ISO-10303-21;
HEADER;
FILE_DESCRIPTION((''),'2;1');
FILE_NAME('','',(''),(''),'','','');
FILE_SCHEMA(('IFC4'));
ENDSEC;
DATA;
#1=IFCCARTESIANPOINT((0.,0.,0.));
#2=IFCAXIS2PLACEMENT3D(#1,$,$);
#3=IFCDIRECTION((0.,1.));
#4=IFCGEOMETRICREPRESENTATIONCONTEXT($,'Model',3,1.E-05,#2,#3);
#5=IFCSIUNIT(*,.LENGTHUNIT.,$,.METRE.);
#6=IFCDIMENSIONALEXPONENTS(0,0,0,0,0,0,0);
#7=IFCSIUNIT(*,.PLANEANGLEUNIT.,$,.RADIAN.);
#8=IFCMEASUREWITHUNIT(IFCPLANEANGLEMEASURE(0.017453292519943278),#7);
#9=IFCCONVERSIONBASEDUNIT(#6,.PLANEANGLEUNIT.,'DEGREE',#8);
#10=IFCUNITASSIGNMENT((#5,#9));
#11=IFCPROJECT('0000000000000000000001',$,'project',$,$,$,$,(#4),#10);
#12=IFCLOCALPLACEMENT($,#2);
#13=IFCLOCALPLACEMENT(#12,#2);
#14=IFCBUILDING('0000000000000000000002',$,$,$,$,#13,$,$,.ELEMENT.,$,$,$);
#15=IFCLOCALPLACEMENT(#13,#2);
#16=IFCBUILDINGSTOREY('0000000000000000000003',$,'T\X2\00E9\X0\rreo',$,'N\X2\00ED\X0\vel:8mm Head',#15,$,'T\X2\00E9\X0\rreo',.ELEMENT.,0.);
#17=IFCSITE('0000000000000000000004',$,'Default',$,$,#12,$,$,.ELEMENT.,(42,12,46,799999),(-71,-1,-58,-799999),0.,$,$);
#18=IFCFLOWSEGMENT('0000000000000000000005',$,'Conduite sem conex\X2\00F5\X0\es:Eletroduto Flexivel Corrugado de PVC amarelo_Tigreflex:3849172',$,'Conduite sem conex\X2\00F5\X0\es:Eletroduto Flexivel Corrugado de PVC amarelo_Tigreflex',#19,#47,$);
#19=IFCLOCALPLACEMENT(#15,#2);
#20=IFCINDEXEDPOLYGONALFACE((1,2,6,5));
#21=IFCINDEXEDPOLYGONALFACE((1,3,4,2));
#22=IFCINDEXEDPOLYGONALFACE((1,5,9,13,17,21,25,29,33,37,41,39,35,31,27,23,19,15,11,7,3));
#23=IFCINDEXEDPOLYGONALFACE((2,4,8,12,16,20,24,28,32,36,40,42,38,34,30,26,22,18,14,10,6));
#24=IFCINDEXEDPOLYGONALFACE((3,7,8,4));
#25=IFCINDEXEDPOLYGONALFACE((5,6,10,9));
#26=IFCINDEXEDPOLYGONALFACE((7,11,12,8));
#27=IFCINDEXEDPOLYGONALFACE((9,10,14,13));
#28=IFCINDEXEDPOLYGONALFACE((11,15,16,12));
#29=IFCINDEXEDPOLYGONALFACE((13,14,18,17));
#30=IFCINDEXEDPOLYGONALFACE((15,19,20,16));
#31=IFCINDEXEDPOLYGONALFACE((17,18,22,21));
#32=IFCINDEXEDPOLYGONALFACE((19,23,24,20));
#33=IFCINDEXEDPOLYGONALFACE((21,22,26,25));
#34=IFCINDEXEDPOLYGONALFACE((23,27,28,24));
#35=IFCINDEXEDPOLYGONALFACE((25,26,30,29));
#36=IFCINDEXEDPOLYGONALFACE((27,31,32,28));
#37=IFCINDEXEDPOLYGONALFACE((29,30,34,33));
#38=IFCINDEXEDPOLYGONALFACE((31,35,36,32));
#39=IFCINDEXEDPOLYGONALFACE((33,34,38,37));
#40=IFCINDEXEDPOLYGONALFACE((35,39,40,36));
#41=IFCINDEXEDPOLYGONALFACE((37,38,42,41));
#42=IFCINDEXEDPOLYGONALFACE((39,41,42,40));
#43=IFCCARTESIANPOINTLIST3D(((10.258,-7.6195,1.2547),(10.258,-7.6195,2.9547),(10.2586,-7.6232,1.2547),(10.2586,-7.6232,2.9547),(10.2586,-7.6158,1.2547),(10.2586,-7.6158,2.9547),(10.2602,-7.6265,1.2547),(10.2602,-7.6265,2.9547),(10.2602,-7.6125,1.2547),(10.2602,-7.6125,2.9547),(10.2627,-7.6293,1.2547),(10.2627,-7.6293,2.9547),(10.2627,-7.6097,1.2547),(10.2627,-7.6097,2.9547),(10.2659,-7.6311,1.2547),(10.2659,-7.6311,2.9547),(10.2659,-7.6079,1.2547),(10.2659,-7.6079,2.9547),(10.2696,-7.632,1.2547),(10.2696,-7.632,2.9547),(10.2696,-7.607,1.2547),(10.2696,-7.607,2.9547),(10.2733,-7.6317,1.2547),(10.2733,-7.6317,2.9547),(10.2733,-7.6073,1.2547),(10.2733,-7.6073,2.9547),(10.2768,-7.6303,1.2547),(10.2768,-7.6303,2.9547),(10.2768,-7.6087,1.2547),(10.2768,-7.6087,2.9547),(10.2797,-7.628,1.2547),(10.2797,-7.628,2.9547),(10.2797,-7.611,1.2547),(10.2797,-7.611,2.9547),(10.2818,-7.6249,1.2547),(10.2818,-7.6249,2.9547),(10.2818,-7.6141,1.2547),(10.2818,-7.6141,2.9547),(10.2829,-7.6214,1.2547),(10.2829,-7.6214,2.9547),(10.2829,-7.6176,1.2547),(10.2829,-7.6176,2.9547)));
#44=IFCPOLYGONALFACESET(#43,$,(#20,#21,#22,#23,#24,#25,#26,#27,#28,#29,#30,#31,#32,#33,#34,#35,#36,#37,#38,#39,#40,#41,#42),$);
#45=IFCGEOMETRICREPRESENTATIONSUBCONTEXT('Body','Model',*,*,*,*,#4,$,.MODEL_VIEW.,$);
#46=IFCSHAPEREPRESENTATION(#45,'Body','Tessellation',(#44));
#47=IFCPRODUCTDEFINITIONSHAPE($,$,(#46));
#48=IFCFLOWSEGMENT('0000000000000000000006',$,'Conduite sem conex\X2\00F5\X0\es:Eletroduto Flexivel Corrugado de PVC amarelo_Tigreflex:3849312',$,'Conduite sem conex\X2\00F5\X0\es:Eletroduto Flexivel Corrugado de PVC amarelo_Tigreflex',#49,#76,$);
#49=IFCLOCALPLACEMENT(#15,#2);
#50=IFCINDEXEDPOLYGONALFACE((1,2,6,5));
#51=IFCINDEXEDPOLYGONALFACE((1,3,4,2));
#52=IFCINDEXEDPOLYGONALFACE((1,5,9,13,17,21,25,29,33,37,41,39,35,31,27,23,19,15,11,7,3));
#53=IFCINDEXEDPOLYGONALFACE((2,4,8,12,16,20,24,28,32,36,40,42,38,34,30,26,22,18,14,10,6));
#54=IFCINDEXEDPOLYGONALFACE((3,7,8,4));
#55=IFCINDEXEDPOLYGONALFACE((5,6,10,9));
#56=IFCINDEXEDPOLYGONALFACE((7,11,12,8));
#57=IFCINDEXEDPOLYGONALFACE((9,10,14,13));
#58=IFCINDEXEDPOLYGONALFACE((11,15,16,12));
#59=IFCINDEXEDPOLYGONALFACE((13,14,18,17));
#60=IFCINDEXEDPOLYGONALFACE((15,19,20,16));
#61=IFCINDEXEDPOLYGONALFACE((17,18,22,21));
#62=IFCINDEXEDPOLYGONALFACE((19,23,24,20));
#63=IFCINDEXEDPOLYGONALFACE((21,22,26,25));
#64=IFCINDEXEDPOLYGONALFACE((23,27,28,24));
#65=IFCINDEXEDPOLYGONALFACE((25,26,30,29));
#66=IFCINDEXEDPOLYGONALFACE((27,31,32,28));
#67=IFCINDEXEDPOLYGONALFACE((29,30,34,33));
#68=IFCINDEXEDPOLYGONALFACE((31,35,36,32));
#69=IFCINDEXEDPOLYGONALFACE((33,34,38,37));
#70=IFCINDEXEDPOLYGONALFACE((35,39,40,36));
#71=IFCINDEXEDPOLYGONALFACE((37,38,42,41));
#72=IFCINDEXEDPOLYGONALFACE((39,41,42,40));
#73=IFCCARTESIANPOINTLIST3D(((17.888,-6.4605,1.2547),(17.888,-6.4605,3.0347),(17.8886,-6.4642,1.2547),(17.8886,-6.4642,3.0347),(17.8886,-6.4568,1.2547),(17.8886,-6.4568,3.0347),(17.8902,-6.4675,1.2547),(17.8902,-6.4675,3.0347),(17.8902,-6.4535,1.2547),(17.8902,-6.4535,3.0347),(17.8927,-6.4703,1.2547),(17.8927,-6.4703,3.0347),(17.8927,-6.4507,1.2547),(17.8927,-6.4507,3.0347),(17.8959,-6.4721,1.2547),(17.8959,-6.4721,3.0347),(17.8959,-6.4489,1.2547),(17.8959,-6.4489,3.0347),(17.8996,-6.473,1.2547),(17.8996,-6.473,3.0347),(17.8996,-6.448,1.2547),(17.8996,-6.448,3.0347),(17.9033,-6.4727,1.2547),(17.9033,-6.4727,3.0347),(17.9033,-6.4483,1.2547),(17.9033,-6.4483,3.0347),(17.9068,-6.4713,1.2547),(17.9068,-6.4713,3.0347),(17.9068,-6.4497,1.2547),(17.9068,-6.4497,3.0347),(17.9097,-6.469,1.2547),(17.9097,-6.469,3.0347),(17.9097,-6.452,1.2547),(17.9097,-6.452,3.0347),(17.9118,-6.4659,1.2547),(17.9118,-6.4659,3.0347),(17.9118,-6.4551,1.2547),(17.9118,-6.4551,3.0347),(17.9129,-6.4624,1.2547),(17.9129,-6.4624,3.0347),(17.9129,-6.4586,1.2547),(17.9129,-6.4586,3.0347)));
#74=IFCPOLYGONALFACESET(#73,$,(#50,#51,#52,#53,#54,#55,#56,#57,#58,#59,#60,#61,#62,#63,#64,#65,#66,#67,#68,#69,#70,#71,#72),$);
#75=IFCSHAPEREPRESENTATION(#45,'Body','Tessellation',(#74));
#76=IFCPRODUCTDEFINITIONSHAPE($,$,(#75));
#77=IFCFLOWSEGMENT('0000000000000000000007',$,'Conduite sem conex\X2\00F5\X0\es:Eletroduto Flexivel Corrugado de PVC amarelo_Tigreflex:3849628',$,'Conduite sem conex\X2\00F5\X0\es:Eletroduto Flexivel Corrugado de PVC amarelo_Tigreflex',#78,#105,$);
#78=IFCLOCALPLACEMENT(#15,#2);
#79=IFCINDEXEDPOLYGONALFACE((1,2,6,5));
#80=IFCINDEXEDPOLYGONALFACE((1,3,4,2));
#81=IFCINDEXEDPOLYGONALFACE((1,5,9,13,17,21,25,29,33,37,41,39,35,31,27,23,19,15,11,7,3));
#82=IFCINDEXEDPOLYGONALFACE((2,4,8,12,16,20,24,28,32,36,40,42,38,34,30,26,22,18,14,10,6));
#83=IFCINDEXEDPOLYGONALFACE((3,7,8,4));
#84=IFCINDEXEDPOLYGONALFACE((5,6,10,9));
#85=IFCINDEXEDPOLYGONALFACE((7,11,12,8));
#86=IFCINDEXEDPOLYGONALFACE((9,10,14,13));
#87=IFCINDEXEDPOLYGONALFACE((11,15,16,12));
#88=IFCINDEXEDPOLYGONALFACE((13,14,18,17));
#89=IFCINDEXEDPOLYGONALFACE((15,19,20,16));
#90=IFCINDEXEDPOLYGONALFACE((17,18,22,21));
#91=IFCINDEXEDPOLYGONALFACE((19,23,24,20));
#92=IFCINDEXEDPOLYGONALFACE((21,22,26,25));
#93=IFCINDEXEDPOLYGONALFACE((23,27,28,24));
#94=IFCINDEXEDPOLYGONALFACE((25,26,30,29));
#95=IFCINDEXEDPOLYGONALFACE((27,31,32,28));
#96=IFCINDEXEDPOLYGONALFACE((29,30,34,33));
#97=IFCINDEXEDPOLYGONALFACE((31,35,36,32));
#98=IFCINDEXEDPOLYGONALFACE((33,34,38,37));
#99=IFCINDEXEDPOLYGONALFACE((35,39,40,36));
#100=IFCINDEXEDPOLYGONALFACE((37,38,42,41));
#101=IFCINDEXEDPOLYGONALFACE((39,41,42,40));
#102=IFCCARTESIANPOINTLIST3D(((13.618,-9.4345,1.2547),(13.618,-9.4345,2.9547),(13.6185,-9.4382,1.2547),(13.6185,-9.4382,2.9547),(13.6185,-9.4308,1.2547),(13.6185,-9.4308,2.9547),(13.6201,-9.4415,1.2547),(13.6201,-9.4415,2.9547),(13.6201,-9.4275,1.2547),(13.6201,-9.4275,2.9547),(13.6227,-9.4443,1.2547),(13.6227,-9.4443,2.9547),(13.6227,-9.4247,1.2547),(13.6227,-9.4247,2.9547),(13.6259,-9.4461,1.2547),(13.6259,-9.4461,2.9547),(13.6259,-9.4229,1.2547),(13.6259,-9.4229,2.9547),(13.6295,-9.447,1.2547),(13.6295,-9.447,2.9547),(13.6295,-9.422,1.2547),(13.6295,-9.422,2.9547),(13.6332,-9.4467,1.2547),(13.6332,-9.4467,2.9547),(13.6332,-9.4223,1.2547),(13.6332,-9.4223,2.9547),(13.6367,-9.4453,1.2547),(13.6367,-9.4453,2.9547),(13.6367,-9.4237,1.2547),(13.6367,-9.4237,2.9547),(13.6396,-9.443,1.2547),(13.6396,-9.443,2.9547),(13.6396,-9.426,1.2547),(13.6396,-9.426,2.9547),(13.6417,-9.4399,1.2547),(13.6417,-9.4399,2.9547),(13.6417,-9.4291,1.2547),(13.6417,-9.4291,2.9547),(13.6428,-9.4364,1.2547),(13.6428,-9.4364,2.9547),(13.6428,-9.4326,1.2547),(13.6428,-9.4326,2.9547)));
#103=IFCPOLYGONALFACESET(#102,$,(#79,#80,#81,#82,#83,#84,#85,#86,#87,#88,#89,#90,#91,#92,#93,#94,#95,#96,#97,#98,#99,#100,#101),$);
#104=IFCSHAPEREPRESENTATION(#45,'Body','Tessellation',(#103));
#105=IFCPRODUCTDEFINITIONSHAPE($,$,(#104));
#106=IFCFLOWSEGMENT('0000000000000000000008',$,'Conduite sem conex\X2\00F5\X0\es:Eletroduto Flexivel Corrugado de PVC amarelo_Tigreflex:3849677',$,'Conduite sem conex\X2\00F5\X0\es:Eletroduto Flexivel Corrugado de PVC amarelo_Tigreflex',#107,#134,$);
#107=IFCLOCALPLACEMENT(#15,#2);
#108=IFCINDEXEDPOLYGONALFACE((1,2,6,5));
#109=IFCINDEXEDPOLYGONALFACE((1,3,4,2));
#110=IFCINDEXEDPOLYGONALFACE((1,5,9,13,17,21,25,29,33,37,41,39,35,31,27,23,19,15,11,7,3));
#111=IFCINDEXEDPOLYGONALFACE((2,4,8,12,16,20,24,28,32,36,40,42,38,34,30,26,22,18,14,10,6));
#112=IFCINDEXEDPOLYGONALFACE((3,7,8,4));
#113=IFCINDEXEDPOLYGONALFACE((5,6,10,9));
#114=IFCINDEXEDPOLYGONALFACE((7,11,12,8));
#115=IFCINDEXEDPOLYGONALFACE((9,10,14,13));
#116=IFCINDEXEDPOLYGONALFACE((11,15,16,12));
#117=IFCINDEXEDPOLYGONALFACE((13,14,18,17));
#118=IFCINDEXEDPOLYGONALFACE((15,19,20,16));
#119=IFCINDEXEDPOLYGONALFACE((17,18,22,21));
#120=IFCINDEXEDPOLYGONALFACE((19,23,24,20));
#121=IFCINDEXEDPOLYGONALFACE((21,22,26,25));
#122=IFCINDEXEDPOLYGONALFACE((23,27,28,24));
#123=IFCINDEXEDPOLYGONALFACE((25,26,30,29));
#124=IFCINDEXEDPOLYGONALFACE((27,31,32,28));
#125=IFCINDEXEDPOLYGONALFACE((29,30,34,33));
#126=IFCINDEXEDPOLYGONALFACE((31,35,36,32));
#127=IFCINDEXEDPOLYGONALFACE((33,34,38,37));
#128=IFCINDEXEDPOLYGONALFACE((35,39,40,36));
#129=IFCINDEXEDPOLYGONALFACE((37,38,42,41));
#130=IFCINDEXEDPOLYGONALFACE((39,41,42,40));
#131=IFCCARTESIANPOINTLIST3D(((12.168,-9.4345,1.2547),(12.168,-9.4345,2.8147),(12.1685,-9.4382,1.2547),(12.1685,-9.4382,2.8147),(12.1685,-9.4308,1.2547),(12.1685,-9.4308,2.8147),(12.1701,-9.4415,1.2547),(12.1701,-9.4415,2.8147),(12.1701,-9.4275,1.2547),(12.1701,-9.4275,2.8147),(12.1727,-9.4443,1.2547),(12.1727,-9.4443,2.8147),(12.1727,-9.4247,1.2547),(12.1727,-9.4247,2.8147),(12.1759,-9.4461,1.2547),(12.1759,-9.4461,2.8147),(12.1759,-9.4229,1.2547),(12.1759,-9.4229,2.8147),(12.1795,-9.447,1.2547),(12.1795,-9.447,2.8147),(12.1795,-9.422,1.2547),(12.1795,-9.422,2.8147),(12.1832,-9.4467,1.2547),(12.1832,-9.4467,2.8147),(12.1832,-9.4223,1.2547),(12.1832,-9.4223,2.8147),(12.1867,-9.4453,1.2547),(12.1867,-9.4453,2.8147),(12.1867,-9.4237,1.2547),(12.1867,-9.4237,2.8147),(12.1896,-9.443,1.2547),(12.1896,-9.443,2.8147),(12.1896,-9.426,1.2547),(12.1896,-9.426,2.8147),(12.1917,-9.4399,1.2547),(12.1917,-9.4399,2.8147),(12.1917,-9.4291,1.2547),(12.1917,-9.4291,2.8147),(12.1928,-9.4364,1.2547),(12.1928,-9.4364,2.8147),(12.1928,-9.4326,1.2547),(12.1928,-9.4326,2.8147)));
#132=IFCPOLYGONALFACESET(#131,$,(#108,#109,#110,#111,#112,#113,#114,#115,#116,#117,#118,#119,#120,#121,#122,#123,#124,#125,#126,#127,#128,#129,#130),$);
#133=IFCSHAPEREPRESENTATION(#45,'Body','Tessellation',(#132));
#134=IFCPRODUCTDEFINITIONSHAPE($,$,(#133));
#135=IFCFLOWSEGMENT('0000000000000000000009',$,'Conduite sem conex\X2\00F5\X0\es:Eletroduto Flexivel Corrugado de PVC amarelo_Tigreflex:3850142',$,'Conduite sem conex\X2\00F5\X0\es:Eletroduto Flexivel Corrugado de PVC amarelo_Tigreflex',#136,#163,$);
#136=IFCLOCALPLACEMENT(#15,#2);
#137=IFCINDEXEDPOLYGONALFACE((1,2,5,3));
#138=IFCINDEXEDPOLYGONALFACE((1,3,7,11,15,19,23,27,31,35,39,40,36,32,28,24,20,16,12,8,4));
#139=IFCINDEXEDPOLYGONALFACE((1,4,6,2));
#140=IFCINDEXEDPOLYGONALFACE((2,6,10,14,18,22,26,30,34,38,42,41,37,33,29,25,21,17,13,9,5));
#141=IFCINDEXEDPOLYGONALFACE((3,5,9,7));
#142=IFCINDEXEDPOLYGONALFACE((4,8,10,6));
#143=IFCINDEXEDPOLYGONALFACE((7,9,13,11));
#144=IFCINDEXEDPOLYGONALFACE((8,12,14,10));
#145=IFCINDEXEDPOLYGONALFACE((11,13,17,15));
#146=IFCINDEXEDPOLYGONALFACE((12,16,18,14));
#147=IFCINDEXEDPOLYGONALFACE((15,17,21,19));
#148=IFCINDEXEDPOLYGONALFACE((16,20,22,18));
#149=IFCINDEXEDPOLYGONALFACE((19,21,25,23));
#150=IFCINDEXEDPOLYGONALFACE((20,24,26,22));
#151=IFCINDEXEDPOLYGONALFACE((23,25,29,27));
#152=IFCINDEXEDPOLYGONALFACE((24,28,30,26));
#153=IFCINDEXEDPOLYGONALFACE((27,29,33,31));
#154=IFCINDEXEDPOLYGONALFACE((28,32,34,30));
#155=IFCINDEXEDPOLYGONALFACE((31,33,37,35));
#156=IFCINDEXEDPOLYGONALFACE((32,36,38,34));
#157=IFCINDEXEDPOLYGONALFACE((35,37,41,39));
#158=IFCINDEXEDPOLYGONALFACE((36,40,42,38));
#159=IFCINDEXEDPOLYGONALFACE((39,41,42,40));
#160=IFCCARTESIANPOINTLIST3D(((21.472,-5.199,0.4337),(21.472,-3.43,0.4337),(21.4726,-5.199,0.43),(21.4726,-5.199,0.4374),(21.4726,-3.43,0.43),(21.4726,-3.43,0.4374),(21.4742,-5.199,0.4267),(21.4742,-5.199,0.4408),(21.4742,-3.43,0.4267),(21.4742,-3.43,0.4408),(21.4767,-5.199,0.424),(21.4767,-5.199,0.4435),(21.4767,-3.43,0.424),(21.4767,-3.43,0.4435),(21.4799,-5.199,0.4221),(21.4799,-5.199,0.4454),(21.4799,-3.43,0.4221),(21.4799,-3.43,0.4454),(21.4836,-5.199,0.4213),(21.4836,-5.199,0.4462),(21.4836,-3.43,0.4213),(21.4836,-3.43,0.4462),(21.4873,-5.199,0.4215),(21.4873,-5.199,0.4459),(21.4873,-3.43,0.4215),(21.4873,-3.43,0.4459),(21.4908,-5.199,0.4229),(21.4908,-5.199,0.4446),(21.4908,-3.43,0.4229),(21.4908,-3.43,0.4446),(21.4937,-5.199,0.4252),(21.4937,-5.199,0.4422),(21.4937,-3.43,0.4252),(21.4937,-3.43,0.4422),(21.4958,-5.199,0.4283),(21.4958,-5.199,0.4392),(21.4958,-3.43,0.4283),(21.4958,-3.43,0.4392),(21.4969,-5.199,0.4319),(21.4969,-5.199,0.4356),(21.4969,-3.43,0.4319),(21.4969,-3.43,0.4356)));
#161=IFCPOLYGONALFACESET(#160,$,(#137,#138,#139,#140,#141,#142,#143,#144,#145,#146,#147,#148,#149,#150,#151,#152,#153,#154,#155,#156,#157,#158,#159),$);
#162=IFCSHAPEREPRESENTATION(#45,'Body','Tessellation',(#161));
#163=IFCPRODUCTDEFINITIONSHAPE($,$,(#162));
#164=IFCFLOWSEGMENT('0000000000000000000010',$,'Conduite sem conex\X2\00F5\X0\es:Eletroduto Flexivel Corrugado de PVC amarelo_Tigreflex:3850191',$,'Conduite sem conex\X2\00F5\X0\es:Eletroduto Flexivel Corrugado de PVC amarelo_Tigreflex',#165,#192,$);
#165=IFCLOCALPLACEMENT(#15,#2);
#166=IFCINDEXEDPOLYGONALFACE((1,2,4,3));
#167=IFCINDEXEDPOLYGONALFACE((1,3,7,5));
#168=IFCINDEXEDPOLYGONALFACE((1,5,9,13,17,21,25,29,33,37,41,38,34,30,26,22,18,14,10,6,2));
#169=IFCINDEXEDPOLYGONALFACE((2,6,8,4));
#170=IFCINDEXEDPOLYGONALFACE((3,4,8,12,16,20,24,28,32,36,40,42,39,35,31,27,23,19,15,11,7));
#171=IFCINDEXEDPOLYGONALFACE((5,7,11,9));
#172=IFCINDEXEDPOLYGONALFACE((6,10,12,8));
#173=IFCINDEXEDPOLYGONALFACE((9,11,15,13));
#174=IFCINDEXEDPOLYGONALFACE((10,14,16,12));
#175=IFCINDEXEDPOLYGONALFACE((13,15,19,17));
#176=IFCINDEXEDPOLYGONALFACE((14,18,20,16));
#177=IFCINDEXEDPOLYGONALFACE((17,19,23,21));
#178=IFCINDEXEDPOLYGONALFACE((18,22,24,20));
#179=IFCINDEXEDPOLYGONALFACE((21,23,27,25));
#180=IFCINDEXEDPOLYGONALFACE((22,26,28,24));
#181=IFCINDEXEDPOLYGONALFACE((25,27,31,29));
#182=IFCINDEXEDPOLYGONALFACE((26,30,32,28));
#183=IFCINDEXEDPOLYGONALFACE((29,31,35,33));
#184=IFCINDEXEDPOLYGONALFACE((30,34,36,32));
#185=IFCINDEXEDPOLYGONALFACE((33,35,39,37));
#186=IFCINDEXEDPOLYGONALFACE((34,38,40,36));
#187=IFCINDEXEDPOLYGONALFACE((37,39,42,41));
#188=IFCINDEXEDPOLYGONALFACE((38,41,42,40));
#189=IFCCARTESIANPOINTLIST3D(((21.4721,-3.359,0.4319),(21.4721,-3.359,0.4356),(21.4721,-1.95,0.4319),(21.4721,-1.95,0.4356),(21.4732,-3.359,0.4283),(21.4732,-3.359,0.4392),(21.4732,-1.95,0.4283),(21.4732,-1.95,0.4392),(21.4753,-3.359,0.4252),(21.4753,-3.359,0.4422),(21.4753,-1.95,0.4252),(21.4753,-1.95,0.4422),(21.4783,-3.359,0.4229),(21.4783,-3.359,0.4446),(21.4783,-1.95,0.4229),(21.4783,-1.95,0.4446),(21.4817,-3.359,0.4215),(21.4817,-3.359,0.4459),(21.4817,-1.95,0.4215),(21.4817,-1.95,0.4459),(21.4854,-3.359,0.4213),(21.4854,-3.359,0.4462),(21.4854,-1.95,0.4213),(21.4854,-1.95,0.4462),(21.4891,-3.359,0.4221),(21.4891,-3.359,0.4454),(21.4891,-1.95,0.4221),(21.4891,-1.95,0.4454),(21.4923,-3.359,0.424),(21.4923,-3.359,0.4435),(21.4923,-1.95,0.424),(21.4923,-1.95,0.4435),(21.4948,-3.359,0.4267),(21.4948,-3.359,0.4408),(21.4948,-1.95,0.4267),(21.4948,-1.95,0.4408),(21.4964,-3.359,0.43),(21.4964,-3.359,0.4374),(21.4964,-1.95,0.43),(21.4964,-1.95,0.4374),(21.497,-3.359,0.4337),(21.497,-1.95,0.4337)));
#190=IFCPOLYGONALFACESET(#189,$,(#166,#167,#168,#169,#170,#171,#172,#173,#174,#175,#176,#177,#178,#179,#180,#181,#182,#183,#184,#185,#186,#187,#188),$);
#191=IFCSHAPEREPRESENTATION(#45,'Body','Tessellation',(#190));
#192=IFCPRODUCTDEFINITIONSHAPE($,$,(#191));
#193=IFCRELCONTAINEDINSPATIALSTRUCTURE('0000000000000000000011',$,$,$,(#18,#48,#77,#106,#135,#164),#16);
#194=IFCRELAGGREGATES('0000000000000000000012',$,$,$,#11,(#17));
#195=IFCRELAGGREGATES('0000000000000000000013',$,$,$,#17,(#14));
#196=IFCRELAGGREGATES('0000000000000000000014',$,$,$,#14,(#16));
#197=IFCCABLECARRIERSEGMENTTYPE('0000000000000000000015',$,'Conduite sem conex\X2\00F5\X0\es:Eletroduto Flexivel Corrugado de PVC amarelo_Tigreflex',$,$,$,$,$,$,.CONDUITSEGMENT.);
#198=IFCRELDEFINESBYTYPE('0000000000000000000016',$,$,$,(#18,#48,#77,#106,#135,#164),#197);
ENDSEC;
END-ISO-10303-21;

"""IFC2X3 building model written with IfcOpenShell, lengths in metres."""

from ifc_helpers import new_model, entity, si_unit, converted_unit, direction, frame, frame_2d, origin, origin_2d_with_axis, place, context, subcontext, project, spatial, circle, extrude, type_object, element, save


model = new_model("IFC2X3")

# Units and contexts
model_context = context("Model", 3, precision=1e-05, world=origin(), true_north=direction((0.0, 1.0)))
body_context = subcontext(model_context, "Body", "Model", "MODEL_VIEW")
ifc_project = project(units=[si_unit("LENGTHUNIT", "METRE"), converted_unit("PLANEANGLEUNIT", "DEGREE", entity("IfcPlaneAngleMeasure", 0.017453292519943278), si_unit("PLANEANGLEUNIT", "RADIAN"), dimensions=[0, 0, 0, 0, 0, 0, 0])], contexts=[model_context])

# Site, building, storey
site_placement = place(None, origin())
site = spatial("IfcSite", under=ifc_project, at=site_placement, Name="Default", CompositionType="ELEMENT", RefLatitude=(42, 12, 46, 799999), RefLongitude=(-71, -1, -58, -799999), RefElevation=0.0)
building_placement = place(site_placement, origin())
building = spatial("IfcBuilding", under=site, at=building_placement, CompositionType="ELEMENT")
storey_placement = place(building_placement, origin())
storey = spatial("IfcBuildingStorey", under=building, at=storey_placement, Name="Térreo", ObjectType="Nível:8mm Head", LongName="Térreo", CompositionType="ELEMENT", Elevation=0.0)

# Flow segments
cable_carrier_segment_type = type_object("IfcCableCarrierSegmentType", Name="Conduite sem conexões:Eletroduto Flexivel Corrugado de PVC amarelo_Tigreflex", PredefinedType="CONDUITSEGMENT")
flow_segment_1_placement = place(storey_placement, origin())
element("IfcFlowSegment", 1, at=flow_segment_1_placement, inside=storey, type_object=cable_carrier_segment_type, Name="Conduite sem conexões:Eletroduto Flexivel Corrugado de PVC amarelo_Tigreflex:3849172", ObjectType="Conduite sem conexões:Eletroduto Flexivel Corrugado de PVC amarelo_Tigreflex", context=body_context, shape_type="SweptSolid", body=[
    extrude(circle(Radius=0.0125, at=origin_2d_with_axis()), frame((10.2705, -7.6195, 1.2547), z_axis=(0.0, 0.0, 1.0), x_axis=(-1.0, 0.0, 0.0)), (0.0, 0.0, 1.0), 1.7),
])
flow_segment_2_placement = place(storey_placement, origin())
element("IfcFlowSegment", 2, at=flow_segment_2_placement, inside=storey, type_object=cable_carrier_segment_type, Name="Conduite sem conexões:Eletroduto Flexivel Corrugado de PVC amarelo_Tigreflex:3849312", ObjectType="Conduite sem conexões:Eletroduto Flexivel Corrugado de PVC amarelo_Tigreflex", context=body_context, shape_type="SweptSolid", body=[
    extrude(circle(Radius=0.0125, at=origin_2d_with_axis()), frame((17.9005, -6.4605, 1.2547), z_axis=(0.0, 0.0, 1.0), x_axis=(-1.0, 0.0, 0.0)), (0.0, 0.0, 1.0), 1.78),
])
flow_segment_3_placement = place(storey_placement, origin())
element("IfcFlowSegment", 3, at=flow_segment_3_placement, inside=storey, type_object=cable_carrier_segment_type, Name="Conduite sem conexões:Eletroduto Flexivel Corrugado de PVC amarelo_Tigreflex:3849628", ObjectType="Conduite sem conexões:Eletroduto Flexivel Corrugado de PVC amarelo_Tigreflex", context=body_context, shape_type="SweptSolid", body=[
    extrude(circle(Radius=0.0125, at=origin_2d_with_axis()), frame((13.6305, -9.4345, 1.2547), z_axis=(0.0, 0.0, 1.0), x_axis=(-1.0, 0.0, 0.0)), (0.0, 0.0, 1.0), 1.7),
])
flow_segment_4_placement = place(storey_placement, origin())
element("IfcFlowSegment", 4, at=flow_segment_4_placement, inside=storey, type_object=cable_carrier_segment_type, Name="Conduite sem conexões:Eletroduto Flexivel Corrugado de PVC amarelo_Tigreflex:3849677", ObjectType="Conduite sem conexões:Eletroduto Flexivel Corrugado de PVC amarelo_Tigreflex", context=body_context, shape_type="SweptSolid", body=[
    extrude(circle(Radius=0.0125, at=origin_2d_with_axis()), frame((12.1805, -9.4345, 1.2547), z_axis=(0.0, 0.0, 1.0), x_axis=(-1.0, 0.0, 0.0)), (0.0, 0.0, 1.0), 1.56),
])
flow_segment_5_placement = place(storey_placement, origin())
element("IfcFlowSegment", 5, at=flow_segment_5_placement, inside=storey, type_object=cable_carrier_segment_type, Name="Conduite sem conexões:Eletroduto Flexivel Corrugado de PVC amarelo_Tigreflex:3850142", ObjectType="Conduite sem conexões:Eletroduto Flexivel Corrugado de PVC amarelo_Tigreflex", context=body_context, shape_type="SweptSolid", body=[
    extrude(circle(Radius=0.0125, at=frame_2d((0.0, 0.0), x_axis=(1.0, 0.0))), frame((21.4845, -5.199, 0.4337), z_axis=(0.0, 1.0, 0.0), x_axis=(-1.0, 0.0, 0.0)), (0.0, 0.0, 1.0), 1.7691),
])
flow_segment_6_placement = place(storey_placement, origin())
element("IfcFlowSegment", 6, at=flow_segment_6_placement, inside=storey, type_object=cable_carrier_segment_type, Name="Conduite sem conexões:Eletroduto Flexivel Corrugado de PVC amarelo_Tigreflex:3850191", ObjectType="Conduite sem conexões:Eletroduto Flexivel Corrugado de PVC amarelo_Tigreflex", context=body_context, shape_type="SweptSolid", body=[
    extrude(circle(Radius=0.0125, at=origin_2d_with_axis()), frame((21.4845, -3.359, 0.4337), z_axis=(0.0, 1.0, 0.0), x_axis=(1.0, 0.0, 0.0)), (0.0, 0.0, 1.0), 1.409),
])

save(model, "model.ifc")
